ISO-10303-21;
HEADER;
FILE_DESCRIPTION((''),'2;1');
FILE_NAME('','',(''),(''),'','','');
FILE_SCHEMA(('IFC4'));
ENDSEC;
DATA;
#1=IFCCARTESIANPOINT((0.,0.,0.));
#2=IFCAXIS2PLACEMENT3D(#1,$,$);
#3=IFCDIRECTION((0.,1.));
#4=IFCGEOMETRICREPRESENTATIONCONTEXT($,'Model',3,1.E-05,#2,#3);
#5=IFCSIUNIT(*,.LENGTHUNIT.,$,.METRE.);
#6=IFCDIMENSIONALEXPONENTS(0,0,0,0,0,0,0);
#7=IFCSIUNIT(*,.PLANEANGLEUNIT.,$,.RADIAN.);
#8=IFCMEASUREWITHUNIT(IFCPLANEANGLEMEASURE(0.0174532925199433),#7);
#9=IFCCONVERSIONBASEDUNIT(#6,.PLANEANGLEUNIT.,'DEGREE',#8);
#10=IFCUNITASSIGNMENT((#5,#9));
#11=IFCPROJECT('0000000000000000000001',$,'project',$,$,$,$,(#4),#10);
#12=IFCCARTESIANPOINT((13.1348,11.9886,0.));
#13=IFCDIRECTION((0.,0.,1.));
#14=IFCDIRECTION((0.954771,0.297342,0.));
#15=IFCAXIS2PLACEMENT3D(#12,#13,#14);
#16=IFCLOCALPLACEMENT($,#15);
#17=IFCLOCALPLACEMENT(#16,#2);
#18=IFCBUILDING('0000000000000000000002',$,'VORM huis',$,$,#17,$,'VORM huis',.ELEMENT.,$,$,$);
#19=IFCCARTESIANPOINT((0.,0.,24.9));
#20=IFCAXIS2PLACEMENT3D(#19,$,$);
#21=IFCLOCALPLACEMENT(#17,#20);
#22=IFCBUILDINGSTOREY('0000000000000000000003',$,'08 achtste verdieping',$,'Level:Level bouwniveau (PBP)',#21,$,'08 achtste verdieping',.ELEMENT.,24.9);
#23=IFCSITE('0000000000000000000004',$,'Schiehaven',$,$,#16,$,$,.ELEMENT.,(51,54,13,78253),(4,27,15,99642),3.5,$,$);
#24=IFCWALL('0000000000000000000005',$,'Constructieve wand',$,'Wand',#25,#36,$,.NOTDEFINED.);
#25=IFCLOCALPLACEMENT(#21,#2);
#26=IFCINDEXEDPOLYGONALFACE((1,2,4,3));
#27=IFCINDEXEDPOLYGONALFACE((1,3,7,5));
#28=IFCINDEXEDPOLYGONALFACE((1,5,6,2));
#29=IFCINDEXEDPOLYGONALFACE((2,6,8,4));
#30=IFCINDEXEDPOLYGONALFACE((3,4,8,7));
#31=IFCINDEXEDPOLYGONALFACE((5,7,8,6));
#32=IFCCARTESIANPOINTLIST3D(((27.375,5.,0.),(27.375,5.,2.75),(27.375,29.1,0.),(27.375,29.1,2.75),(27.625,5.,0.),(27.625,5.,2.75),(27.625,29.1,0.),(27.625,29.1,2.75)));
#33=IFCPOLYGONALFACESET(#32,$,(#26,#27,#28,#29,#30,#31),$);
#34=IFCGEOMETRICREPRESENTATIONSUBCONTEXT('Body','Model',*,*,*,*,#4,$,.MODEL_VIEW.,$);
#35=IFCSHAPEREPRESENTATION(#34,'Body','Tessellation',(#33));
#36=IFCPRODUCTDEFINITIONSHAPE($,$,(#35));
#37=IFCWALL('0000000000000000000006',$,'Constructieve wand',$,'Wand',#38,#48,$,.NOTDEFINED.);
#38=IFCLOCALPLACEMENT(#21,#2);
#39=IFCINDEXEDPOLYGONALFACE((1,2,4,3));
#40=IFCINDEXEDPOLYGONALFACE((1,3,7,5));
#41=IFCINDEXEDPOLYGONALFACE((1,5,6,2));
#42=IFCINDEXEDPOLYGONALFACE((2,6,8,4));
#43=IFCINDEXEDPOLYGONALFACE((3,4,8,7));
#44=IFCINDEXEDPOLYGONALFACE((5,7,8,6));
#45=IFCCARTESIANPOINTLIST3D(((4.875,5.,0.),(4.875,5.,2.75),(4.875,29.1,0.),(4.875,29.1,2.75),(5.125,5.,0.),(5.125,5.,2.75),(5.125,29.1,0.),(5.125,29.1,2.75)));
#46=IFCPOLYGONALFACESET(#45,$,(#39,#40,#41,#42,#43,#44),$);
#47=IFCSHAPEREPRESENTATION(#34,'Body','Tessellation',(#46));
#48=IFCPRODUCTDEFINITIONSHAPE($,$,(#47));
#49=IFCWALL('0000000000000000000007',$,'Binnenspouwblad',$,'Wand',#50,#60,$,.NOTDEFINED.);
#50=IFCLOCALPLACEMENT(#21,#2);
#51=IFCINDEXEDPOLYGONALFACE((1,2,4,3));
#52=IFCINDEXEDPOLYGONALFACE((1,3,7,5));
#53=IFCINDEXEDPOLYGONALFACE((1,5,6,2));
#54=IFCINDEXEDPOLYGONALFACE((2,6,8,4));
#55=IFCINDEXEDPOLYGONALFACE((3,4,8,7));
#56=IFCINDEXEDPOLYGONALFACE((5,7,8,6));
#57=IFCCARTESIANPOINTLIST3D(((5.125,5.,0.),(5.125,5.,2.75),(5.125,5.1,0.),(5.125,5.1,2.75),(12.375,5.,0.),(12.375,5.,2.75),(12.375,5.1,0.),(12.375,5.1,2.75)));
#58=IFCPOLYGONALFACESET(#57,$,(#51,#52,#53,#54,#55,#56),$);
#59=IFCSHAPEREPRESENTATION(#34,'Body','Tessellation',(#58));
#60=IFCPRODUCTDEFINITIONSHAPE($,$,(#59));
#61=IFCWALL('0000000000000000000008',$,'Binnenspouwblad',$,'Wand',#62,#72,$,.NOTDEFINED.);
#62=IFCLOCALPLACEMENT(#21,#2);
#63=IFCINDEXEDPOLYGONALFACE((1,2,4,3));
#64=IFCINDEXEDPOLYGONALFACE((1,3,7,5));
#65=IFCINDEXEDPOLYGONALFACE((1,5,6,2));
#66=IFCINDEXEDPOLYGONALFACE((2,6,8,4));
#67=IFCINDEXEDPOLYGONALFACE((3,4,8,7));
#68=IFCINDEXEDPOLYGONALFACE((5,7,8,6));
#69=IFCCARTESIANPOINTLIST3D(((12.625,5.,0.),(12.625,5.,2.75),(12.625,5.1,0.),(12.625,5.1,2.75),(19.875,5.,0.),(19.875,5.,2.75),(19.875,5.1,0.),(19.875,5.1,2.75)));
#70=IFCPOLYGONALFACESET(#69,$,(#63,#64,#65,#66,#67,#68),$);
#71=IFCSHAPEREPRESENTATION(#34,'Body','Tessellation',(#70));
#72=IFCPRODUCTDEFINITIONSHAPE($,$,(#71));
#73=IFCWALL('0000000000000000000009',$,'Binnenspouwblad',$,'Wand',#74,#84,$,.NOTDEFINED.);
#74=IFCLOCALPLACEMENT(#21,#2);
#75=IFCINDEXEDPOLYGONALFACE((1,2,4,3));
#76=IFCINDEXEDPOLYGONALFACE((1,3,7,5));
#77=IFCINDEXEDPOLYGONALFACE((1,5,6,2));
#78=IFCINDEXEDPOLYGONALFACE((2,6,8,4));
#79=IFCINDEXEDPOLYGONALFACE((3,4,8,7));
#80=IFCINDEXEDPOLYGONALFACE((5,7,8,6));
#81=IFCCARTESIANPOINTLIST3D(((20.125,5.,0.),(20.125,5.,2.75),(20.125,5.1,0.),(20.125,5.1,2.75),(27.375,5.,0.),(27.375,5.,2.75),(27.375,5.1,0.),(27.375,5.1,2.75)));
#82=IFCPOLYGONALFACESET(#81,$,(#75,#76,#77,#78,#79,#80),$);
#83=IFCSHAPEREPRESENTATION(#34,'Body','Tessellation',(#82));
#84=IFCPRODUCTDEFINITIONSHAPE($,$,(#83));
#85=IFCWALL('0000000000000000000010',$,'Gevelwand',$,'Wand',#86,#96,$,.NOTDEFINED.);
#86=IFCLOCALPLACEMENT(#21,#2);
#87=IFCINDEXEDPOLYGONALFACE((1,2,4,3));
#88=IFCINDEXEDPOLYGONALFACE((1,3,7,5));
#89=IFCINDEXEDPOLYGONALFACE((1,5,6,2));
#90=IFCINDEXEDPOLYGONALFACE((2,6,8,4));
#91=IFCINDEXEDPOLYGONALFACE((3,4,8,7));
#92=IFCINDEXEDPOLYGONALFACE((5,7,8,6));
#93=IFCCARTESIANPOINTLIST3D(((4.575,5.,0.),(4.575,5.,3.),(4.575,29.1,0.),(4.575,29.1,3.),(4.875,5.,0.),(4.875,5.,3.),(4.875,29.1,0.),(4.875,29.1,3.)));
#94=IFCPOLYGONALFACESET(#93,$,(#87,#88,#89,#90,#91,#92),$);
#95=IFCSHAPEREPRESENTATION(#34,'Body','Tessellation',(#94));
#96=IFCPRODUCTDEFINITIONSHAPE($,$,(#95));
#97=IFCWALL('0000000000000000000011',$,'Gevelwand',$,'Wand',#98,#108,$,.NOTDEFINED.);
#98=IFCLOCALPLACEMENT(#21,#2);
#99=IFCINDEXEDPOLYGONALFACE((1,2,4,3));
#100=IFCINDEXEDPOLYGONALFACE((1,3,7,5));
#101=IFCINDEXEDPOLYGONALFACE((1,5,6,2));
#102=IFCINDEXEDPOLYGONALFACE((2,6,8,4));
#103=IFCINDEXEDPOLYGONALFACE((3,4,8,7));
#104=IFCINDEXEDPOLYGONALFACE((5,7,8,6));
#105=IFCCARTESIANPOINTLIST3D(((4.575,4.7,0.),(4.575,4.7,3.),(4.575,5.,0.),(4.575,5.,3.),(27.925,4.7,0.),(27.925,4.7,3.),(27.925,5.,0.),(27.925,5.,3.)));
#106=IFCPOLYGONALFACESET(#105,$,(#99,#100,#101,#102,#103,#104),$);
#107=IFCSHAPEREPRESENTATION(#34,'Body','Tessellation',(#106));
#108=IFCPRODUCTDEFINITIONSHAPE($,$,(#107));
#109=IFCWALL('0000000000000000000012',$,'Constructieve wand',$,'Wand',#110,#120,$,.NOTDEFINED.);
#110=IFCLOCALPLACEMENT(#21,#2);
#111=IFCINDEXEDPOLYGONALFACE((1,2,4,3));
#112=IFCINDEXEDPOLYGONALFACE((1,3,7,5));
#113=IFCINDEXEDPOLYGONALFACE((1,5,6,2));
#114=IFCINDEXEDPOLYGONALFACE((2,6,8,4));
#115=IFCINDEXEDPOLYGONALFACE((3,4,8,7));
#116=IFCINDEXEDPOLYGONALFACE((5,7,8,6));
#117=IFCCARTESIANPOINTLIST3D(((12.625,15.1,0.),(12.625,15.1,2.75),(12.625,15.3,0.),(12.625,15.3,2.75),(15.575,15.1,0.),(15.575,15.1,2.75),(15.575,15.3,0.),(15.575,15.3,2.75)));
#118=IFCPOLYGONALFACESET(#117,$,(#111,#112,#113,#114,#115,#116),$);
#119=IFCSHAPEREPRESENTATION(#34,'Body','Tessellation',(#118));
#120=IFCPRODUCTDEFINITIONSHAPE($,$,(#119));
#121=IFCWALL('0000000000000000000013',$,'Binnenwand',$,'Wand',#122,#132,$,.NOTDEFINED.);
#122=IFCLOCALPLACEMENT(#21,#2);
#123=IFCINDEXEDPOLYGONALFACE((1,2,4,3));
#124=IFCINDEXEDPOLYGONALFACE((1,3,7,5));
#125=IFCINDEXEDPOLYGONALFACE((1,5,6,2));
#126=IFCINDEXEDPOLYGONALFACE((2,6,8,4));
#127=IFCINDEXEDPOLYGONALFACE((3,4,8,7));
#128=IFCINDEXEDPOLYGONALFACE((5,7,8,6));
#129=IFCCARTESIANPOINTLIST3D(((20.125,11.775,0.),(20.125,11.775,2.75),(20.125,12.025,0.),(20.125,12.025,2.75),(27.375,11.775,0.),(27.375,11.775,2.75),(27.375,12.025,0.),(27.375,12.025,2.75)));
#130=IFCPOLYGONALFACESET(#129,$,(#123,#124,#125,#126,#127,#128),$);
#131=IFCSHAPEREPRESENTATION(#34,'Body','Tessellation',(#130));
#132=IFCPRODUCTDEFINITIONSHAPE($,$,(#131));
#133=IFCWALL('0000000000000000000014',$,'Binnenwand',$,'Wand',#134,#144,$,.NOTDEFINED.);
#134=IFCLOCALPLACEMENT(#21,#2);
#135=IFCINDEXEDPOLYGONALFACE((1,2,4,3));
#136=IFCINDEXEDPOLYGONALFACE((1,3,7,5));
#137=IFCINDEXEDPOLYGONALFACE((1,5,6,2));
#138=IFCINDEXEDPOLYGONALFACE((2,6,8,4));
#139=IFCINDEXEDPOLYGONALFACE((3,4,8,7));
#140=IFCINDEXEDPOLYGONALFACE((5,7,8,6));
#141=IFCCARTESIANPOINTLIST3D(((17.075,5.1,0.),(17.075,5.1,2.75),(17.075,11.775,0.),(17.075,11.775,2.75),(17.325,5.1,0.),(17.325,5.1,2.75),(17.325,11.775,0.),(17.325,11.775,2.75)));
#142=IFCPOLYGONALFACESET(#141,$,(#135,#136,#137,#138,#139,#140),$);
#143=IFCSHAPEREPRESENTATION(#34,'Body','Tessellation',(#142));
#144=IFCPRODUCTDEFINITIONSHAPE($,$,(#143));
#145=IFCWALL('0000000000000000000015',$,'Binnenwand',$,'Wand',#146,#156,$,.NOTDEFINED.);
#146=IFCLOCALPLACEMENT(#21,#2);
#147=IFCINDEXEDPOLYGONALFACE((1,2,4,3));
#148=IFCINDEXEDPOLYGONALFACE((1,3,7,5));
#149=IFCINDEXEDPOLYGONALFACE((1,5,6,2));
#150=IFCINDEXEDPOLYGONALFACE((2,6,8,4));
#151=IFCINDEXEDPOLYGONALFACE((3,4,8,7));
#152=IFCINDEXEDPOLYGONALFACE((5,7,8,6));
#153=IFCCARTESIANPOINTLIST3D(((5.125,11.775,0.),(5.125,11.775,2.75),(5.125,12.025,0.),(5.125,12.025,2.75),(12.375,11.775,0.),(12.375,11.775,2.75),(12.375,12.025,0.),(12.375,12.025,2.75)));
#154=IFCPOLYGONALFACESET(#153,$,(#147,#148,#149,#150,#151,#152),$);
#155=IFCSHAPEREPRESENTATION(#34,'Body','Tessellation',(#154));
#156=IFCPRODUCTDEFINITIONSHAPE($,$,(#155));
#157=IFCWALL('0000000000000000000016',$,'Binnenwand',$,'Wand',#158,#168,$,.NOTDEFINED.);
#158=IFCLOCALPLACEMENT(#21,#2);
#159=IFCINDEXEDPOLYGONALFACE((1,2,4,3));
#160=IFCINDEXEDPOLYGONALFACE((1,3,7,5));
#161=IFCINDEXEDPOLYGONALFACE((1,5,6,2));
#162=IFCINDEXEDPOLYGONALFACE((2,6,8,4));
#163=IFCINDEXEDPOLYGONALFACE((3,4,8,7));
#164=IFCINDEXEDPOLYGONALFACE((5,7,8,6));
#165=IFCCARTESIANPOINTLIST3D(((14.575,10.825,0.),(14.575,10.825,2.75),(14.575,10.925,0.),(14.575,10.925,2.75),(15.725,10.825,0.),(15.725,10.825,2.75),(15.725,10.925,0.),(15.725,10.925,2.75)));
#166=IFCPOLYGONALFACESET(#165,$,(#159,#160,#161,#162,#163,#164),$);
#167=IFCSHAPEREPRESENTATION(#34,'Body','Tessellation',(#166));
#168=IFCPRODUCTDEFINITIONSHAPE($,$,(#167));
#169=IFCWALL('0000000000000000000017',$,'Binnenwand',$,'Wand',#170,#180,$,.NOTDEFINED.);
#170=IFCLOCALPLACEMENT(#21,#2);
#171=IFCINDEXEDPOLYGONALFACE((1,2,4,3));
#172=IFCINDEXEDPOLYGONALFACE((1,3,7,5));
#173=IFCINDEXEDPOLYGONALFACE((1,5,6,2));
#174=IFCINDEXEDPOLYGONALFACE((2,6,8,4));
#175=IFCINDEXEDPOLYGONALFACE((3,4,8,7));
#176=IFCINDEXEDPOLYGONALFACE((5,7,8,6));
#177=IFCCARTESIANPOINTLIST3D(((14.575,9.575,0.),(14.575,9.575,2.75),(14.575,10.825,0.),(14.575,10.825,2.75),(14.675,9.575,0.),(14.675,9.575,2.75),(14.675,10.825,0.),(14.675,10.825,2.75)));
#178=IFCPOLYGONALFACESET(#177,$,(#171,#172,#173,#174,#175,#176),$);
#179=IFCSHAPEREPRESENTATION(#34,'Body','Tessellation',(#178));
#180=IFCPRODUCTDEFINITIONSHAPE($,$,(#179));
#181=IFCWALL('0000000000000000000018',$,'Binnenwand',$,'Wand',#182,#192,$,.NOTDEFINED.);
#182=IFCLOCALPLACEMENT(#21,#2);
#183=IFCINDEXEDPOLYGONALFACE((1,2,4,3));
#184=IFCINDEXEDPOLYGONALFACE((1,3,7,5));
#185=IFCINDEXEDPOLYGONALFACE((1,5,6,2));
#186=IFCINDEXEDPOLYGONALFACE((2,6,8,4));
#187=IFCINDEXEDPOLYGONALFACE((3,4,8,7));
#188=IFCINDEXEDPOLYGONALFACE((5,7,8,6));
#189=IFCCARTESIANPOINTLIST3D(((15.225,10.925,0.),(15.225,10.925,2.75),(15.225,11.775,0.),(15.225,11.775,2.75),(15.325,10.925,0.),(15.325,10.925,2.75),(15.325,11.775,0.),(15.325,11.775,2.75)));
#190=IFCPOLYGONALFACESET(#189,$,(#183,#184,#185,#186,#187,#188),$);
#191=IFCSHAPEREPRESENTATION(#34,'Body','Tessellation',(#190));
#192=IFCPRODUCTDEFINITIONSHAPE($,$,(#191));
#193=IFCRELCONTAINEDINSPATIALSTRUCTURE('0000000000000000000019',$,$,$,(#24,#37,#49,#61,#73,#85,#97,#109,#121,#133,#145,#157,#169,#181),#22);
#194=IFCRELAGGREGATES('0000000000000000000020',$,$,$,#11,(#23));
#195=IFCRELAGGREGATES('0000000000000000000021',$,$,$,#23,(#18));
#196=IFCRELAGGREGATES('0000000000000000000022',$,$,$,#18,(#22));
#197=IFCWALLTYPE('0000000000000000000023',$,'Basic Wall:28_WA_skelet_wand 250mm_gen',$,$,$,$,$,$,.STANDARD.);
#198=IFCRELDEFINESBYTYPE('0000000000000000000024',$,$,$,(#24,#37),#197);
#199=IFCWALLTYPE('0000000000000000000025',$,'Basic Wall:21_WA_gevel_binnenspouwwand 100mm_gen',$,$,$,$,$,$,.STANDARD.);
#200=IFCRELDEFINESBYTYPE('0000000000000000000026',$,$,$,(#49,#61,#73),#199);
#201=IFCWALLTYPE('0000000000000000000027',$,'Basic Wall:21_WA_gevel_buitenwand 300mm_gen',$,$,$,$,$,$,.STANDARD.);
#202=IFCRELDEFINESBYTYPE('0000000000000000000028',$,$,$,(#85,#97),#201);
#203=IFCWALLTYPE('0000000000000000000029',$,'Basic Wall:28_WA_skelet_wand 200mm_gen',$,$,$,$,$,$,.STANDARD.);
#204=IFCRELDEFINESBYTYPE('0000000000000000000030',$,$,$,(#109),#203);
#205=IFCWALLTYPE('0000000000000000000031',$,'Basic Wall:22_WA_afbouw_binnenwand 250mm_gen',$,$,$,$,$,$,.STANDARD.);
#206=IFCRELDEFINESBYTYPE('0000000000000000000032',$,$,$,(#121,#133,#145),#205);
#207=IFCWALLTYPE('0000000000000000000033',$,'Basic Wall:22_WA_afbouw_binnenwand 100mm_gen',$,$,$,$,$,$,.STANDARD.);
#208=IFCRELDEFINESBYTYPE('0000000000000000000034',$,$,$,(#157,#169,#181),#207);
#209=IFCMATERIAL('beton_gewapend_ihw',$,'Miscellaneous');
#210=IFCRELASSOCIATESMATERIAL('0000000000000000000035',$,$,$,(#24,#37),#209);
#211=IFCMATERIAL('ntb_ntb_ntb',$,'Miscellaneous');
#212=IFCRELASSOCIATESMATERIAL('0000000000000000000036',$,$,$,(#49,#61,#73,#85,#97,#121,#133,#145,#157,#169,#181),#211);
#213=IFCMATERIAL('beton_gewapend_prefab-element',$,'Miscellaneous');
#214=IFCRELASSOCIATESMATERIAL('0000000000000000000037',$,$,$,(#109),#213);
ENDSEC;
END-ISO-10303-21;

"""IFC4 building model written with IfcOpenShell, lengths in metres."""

from ifc_helpers import new_model, entity, si_unit, converted_unit, direction, frame, origin, place, context, subcontext, project, spatial, indexed_curve, outline, extrude, material, type_object, element, save


model = new_model("IFC4")

# Units and contexts
model_context = context("Model", 3, precision=1e-05, world=origin(), true_north=direction((0.0, 1.0)))
body_context = subcontext(model_context, "Body", "Model", "MODEL_VIEW")
ifc_project = project(units=[si_unit("LENGTHUNIT", "METRE"), converted_unit("PLANEANGLEUNIT", "DEGREE", entity("IfcPlaneAngleMeasure", 0.0174532925199433), si_unit("PLANEANGLEUNIT", "RADIAN"), dimensions=[0, 0, 0, 0, 0, 0, 0])], contexts=[model_context])

# Site, building, storey
site_placement = place(None, frame((13.1348, 11.9886, 0.0), z_axis=(0.0, 0.0, 1.0), x_axis=(0.954771, 0.297342, 0.0)))
site = spatial("IfcSite", under=ifc_project, at=site_placement, Name="Schiehaven", CompositionType="ELEMENT", RefLatitude=(51, 54, 13, 78253), RefLongitude=(4, 27, 15, 99642), RefElevation=3.5)
building_placement = place(site_placement, origin())
building = spatial("IfcBuilding", under=site, at=building_placement, Name="VORM huis", LongName="VORM huis", CompositionType="ELEMENT")
storey_placement = place(building_placement, frame((0.0, 0.0, 24.9)))
storey = spatial("IfcBuildingStorey", under=building, at=storey_placement, Name="08 achtste verdieping", ObjectType="Level:Level bouwniveau (PBP)", LongName="08 achtste verdieping", CompositionType="ELEMENT", Elevation=24.9)

# Shared definitions
ifc_material_1 = material(Name="beton_gewapend_ihw", Category="Miscellaneous")

# Shared definitions
ifc_material_2 = material(Name="beton_gewapend_prefab-element", Category="Miscellaneous")

# Walls
wall_type_1 = type_object("IfcWallType", Name="Basic Wall:28_WA_skelet_wand 250mm_gen", PredefinedType="STANDARD")
wall_1_placement = place(storey_placement, frame((27.5, 5.0, 0.0), z_axis=(0.0, 0.0, 1.0), x_axis=(0.0, 1.0, 0.0)))
element("IfcWall", 1, at=wall_1_placement, inside=storey, type_object=wall_type_1, material=ifc_material_1, Name="Constructieve wand", ObjectType="Wand", PredefinedType="NOTDEFINED", context=body_context, shape_type="SweptSolid", body=[
    extrude(outline(indexed_curve([(24.1, 0.125), (0.0, 0.125), (0.0, -0.125), (24.1, -0.125), (24.1, 0.125)], self_intersect=False)), origin(), (0.0, 0.0, 1.0), 2.75),
])
wall_2_placement = place(storey_placement, frame((5.0, 5.0, 0.0), z_axis=(0.0, 0.0, 1.0), x_axis=(0.0, 1.0, 0.0)))
element("IfcWall", 2, at=wall_2_placement, inside=storey, type_object=wall_type_1, material=ifc_material_1, Name="Constructieve wand", ObjectType="Wand", PredefinedType="NOTDEFINED", context=body_context, shape_type="SweptSolid", body=[
    extrude(outline(indexed_curve([(24.1, 0.125), (0.0, 0.125), (0.0, -0.125), (24.1, -0.125), (24.1, 0.125)], self_intersect=False)), origin(), (0.0, 0.0, 1.0), 2.75),
])
ifc_material_3 = material(Name="ntb_ntb_ntb", Category="Miscellaneous")
wall_type_2 = type_object("IfcWallType", Name="Basic Wall:21_WA_gevel_binnenspouwwand 100mm_gen", PredefinedType="STANDARD")
wall_3_placement = place(storey_placement, frame((5.125, 5.05, 0.0)))
element("IfcWall", 3, at=wall_3_placement, inside=storey, type_object=wall_type_2, material=ifc_material_3, Name="Binnenspouwblad", ObjectType="Wand", PredefinedType="NOTDEFINED", context=body_context, shape_type="SweptSolid", body=[
    extrude(outline(indexed_curve([(7.25, 0.05), (0.0, 0.05), (0.0, -0.05), (7.25, -0.05), (7.25, 0.05)], self_intersect=False)), origin(), (0.0, 0.0, 1.0), 2.75),
])
wall_4_placement = place(storey_placement, frame((19.875, 5.05, 0.0), z_axis=(0.0, 0.0, 1.0), x_axis=(-1.0, 0.0, 0.0)))
element("IfcWall", 4, at=wall_4_placement, inside=storey, type_object=wall_type_2, material=ifc_material_3, Name="Binnenspouwblad", ObjectType="Wand", PredefinedType="NOTDEFINED", context=body_context, shape_type="SweptSolid", body=[
    extrude(outline(indexed_curve([(7.25, 0.05), (0.0, 0.05), (0.0, -0.05), (7.25, -0.05), (7.25, 0.05)], self_intersect=False)), origin(), (0.0, 0.0, 1.0), 2.75),
])
wall_5_placement = place(storey_placement, frame((20.125, 5.05, 0.0)))
element("IfcWall", 5, at=wall_5_placement, inside=storey, type_object=wall_type_2, material=ifc_material_3, Name="Binnenspouwblad", ObjectType="Wand", PredefinedType="NOTDEFINED", context=body_context, shape_type="SweptSolid", body=[
    extrude(outline(indexed_curve([(7.25, 0.05), (0.0, 0.05), (0.0, -0.05), (7.25, -0.05), (7.25, 0.05)], self_intersect=False)), origin(), (0.0, 0.0, 1.0), 2.75),
])
wall_type_3 = type_object("IfcWallType", Name="Basic Wall:21_WA_gevel_buitenwand 300mm_gen", PredefinedType="STANDARD")
wall_6_placement = place(storey_placement, frame((4.725, 5.0, 0.0), z_axis=(0.0, 0.0, 1.0), x_axis=(0.0, 1.0, 0.0)))
element("IfcWall", 6, at=wall_6_placement, inside=storey, type_object=wall_type_3, material=ifc_material_3, Name="Gevelwand", ObjectType="Wand", PredefinedType="NOTDEFINED", context=body_context, shape_type="SweptSolid", body=[
    extrude(outline(indexed_curve([(24.1, 0.15), (0.0, 0.15), (0.0, -0.15), (24.1, -0.15), (24.1, 0.15)], self_intersect=False)), origin(), (0.0, 0.0, 1.0), 3.0),
])
wall_7_placement = place(storey_placement, frame((27.925, 4.85, 0.0), z_axis=(0.0, 0.0, 1.0), x_axis=(-1.0, 0.0, 0.0)))
element("IfcWall", 7, at=wall_7_placement, inside=storey, type_object=wall_type_3, material=ifc_material_3, Name="Gevelwand", ObjectType="Wand", PredefinedType="NOTDEFINED", context=body_context, shape_type="SweptSolid", body=[
    extrude(outline(indexed_curve([(23.35, 0.15), (0.0, 0.15), (0.0, -0.15), (23.35, -0.15), (23.35, 0.15)], self_intersect=False)), origin(), (0.0, 0.0, 1.0), 3.0),
])
wall_type_4 = type_object("IfcWallType", Name="Basic Wall:28_WA_skelet_wand 200mm_gen", PredefinedType="STANDARD")
wall_8_placement = place(storey_placement, frame((12.625, 15.2, 0.0)))
element("IfcWall", 8, at=wall_8_placement, inside=storey, type_object=wall_type_4, material=ifc_material_2, Name="Constructieve wand", ObjectType="Wand", PredefinedType="NOTDEFINED", context=body_context, shape_type="SweptSolid", body=[
    extrude(outline(indexed_curve([(2.95, 0.1), (0.0, 0.1), (0.0, -0.1), (2.95, -0.1), (2.95, 0.1)], self_intersect=False)), origin(), (0.0, 0.0, 1.0), 2.75),
])
wall_type_5 = type_object("IfcWallType", Name="Basic Wall:22_WA_afbouw_binnenwand 250mm_gen", PredefinedType="STANDARD")
wall_9_placement = place(storey_placement, frame((20.125, 11.9, 0.0)))
element("IfcWall", 9, at=wall_9_placement, inside=storey, type_object=wall_type_5, material=ifc_material_3, Name="Binnenwand", ObjectType="Wand", PredefinedType="NOTDEFINED", context=body_context, shape_type="SweptSolid", body=[
    extrude(outline(indexed_curve([(7.25, 0.125), (0.0, 0.125), (0.0, -0.125), (7.25, -0.125), (7.25, 0.125)], self_intersect=False)), origin(), (0.0, 0.0, 1.0), 2.75),
])
wall_10_placement = place(storey_placement, frame((17.2, 11.775, 0.0), z_axis=(0.0, 0.0, 1.0), x_axis=(0.0, -1.0, 0.0)))
element("IfcWall", 10, at=wall_10_placement, inside=storey, type_object=wall_type_5, material=ifc_material_3, Name="Binnenwand", ObjectType="Wand", PredefinedType="NOTDEFINED", context=body_context, shape_type="SweptSolid", body=[
    extrude(outline(indexed_curve([(6.675, 0.125), (0.0, 0.125), (0.0, -0.125), (6.675, -0.125), (6.675, 0.125)], self_intersect=False)), origin(), (0.0, 0.0, 1.0), 2.75),
])
wall_11_placement = place(storey_placement, frame((12.375, 11.9, 0.0), z_axis=(0.0, 0.0, 1.0), x_axis=(-1.0, 0.0, 0.0)))
element("IfcWall", 11, at=wall_11_placement, inside=storey, type_object=wall_type_5, material=ifc_material_3, Name="Binnenwand", ObjectType="Wand", PredefinedType="NOTDEFINED", context=body_context, shape_type="SweptSolid", body=[
    extrude(outline(indexed_curve([(7.25, 0.125), (0.0, 0.125), (0.0, -0.125), (7.25, -0.125), (7.25, 0.125)], self_intersect=False)), origin(), (0.0, 0.0, 1.0), 2.75),
])
wall_type_6 = type_object("IfcWallType", Name="Basic Wall:22_WA_afbouw_binnenwand 100mm_gen", PredefinedType="STANDARD")
wall_12_placement = place(storey_placement, frame((14.575, 10.875, 0.0)))
element("IfcWall", 12, at=wall_12_placement, inside=storey, type_object=wall_type_6, material=ifc_material_3, Name="Binnenwand", ObjectType="Wand", PredefinedType="NOTDEFINED", context=body_context, shape_type="SweptSolid", body=[
    extrude(outline(indexed_curve([(1.15, 0.05), (0.0, 0.05), (0.0, -0.05), (1.15, -0.05), (1.15, 0.05)], self_intersect=False)), origin(), (0.0, 0.0, 1.0), 2.75),
])
wall_13_placement = place(storey_placement, frame((14.625, 10.825, 0.0), z_axis=(0.0, 0.0, 1.0), x_axis=(0.0, -1.0, 0.0)))
element("IfcWall", 13, at=wall_13_placement, inside=storey, type_object=wall_type_6, material=ifc_material_3, Name="Binnenwand", ObjectType="Wand", PredefinedType="NOTDEFINED", context=body_context, shape_type="SweptSolid", body=[
    extrude(outline(indexed_curve([(1.25, 0.05), (0.0, 0.05), (0.0, -0.05), (1.25, -0.05), (1.25, 0.05)], self_intersect=False)), origin(), (0.0, 0.0, 1.0), 2.75),
])
wall_14_placement = place(storey_placement, frame((15.275, 11.775, 0.0), z_axis=(0.0, 0.0, 1.0), x_axis=(0.0, -1.0, 0.0)))
element("IfcWall", 14, at=wall_14_placement, inside=storey, type_object=wall_type_6, material=ifc_material_3, Name="Binnenwand", ObjectType="Wand", PredefinedType="NOTDEFINED", context=body_context, shape_type="SweptSolid", body=[
    extrude(outline(indexed_curve([(0.85, 0.05), (0.0, 0.05), (0.0, -0.05), (0.85, -0.05), (0.85, 0.05)], self_intersect=False)), origin(), (0.0, 0.0, 1.0), 2.75),
])

save(model, "model.ifc")
